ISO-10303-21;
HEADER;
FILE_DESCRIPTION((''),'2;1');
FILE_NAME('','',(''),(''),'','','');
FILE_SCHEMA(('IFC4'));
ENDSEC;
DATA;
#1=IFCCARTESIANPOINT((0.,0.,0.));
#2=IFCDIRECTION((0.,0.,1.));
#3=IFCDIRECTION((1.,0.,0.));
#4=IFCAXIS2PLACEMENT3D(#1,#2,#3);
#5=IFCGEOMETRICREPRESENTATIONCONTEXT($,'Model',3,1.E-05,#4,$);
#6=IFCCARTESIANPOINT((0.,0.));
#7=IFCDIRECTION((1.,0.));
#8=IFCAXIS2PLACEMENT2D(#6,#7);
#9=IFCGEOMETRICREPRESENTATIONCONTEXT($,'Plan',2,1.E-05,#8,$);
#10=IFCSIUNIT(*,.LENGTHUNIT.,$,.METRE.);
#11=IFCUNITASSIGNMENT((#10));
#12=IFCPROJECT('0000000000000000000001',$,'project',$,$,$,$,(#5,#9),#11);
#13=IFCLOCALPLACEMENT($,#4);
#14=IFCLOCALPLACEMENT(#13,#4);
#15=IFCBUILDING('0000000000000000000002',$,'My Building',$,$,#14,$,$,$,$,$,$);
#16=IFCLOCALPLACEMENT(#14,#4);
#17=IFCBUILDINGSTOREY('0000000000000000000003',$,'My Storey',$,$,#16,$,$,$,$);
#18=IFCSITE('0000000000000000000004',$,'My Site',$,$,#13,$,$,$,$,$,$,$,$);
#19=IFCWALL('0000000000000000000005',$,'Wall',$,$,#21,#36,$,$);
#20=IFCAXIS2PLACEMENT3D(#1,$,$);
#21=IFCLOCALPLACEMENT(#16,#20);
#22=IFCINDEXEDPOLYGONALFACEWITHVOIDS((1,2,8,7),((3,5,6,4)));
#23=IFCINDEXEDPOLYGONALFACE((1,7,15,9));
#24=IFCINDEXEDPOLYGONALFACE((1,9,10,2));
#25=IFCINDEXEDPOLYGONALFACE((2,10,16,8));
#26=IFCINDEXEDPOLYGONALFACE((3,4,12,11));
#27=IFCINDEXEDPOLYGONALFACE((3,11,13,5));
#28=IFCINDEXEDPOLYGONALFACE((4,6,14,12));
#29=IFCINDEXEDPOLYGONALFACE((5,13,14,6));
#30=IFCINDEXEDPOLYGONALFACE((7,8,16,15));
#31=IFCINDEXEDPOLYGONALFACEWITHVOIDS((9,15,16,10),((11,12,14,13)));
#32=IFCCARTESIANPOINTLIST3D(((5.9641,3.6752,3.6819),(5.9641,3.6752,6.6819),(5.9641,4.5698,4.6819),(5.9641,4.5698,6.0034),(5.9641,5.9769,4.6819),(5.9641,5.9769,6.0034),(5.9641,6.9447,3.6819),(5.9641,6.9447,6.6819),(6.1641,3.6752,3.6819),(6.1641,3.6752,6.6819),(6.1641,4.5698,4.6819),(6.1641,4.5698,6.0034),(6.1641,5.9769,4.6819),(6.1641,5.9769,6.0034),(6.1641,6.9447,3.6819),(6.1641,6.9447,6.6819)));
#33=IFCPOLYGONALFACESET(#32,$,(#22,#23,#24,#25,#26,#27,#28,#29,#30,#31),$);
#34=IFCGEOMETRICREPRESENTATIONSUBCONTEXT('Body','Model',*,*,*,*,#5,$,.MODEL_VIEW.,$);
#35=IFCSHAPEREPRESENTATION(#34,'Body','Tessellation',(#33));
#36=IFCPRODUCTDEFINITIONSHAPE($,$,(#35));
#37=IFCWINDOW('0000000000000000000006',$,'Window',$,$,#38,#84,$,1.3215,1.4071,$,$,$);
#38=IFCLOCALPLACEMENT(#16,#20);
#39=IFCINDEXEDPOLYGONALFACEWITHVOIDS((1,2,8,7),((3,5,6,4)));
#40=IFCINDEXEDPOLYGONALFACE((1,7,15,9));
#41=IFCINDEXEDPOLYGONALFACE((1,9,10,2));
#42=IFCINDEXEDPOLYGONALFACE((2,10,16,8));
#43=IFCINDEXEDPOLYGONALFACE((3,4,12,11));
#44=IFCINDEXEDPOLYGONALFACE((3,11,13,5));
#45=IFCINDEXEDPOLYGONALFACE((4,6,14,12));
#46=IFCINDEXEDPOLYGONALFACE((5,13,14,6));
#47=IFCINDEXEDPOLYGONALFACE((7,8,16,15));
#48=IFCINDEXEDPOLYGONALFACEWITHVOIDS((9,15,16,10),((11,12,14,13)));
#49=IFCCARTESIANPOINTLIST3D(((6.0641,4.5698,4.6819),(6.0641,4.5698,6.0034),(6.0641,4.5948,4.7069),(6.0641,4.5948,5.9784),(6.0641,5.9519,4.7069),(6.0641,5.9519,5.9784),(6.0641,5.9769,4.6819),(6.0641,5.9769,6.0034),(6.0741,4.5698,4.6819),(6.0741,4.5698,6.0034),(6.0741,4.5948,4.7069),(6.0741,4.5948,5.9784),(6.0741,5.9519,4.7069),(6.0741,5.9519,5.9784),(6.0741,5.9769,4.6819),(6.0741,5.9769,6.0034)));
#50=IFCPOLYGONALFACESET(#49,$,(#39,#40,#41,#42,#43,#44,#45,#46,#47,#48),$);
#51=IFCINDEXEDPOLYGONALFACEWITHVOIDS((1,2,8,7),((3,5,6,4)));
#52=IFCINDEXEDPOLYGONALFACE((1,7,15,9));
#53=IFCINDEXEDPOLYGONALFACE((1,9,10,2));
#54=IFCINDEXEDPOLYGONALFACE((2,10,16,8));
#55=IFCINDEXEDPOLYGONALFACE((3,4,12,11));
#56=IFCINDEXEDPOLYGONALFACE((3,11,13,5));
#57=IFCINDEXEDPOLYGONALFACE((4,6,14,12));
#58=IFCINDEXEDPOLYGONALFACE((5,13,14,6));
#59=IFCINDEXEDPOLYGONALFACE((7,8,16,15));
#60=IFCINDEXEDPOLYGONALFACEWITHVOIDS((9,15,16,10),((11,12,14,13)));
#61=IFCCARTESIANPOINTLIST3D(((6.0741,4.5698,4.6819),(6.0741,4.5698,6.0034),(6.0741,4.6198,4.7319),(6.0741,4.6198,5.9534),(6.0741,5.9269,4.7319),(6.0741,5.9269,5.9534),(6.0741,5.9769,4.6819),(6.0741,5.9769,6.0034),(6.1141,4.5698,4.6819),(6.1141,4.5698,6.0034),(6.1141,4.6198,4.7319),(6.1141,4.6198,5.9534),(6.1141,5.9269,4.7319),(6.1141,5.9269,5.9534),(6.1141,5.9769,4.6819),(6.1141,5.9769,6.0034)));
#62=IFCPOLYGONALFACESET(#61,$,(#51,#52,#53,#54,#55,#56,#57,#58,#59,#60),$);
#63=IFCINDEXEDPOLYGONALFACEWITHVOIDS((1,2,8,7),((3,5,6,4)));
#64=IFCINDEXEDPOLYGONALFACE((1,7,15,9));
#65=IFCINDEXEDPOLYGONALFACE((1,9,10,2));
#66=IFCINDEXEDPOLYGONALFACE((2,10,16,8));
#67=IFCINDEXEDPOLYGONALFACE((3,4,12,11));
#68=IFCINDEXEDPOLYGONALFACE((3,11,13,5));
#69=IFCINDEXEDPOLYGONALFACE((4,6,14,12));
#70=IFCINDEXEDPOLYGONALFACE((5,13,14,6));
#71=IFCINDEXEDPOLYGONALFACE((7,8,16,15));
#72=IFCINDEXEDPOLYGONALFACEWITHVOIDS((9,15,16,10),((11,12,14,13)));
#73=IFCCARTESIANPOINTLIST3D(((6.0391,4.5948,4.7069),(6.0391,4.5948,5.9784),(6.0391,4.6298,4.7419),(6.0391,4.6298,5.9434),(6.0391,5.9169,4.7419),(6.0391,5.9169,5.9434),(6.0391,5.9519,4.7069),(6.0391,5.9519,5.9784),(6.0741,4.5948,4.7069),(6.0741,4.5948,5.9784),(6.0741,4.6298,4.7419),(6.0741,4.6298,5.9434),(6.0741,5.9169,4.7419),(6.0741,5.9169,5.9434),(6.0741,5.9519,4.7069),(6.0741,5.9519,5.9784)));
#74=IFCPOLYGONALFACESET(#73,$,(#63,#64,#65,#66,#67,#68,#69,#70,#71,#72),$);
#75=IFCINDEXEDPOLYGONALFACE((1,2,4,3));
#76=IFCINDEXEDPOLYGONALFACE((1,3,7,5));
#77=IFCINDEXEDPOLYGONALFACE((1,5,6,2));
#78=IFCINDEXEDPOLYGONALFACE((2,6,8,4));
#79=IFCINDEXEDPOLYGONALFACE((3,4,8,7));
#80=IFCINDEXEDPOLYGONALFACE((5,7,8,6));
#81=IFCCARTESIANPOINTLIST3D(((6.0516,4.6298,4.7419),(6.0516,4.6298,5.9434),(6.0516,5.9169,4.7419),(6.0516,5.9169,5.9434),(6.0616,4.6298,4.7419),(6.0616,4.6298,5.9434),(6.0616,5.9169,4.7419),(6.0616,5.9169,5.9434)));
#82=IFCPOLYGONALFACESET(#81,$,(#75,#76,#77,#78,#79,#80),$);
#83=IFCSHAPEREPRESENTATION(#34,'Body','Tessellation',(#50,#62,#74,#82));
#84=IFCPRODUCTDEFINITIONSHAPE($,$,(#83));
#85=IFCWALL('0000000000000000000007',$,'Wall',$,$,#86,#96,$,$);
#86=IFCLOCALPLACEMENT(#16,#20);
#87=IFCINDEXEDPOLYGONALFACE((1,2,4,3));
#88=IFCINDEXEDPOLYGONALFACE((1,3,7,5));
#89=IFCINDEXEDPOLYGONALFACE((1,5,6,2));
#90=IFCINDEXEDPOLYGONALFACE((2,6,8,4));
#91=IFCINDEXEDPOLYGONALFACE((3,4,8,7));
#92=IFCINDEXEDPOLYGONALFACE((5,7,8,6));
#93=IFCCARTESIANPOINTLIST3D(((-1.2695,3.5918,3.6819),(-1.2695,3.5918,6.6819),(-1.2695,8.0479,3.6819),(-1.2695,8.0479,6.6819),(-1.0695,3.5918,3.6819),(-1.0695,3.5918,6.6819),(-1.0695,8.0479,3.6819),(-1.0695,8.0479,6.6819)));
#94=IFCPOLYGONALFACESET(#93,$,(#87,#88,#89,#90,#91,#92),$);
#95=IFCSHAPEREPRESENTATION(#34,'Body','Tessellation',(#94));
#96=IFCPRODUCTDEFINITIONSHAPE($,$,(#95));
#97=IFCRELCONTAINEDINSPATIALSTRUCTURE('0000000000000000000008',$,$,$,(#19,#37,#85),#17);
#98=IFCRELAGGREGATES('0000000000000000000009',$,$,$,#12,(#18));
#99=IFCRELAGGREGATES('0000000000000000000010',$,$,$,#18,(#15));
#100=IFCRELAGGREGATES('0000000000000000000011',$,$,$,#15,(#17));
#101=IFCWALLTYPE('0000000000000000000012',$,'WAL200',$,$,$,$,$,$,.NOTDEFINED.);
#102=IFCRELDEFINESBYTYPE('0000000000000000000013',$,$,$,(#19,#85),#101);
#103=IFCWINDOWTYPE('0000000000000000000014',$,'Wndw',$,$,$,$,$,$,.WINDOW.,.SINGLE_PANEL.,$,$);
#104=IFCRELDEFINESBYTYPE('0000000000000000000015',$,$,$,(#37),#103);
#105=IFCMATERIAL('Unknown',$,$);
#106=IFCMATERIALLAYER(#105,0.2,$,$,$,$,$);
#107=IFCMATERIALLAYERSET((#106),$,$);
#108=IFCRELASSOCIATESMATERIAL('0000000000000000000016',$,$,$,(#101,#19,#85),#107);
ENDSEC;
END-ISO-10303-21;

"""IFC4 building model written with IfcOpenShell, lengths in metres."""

from ifc_helpers import new_model, entity, si_unit, frame, origin_with_axes, origin_2d_with_axis, place, context, subcontext, project, spatial, line, indexed_curve, outline, extrude, shape, source, transform, mapped, material, layer, layer_set, layer_usage, type_object, type_shapes, element, fill, save


model = new_model("IFC4")

# Units and contexts
model_context = context("Model", 3, precision=1e-05, world=origin_with_axes())
plan_context = context("Plan", 2, precision=1e-05, world=origin_2d_with_axis())
body_context_1 = subcontext(model_context, "Body", "Model", "MODEL_VIEW")
body_context_2 = subcontext(plan_context, "Body", "Plan", "PLAN_VIEW")
ifc_project = project(units=[si_unit("LENGTHUNIT", "METRE")], contexts=[model_context, plan_context])

# Site, building, storey
site_placement = place(None, origin_with_axes())
site = spatial("IfcSite", under=ifc_project, at=site_placement, Name="My Site")
building_placement = place(site_placement, origin_with_axes())
building = spatial("IfcBuilding", under=site, at=building_placement, Name="My Building")
storey_placement = place(building_placement, origin_with_axes())
storey = spatial("IfcBuildingStorey", under=building, at=storey_placement, Name="My Storey")

# Shared definitions
ifc_material = material(Name="Unknown")

# Shared definitions
ifc_layer = layer(ifc_material, 0.2)
ifc_layer_set = layer_set([ifc_layer])
wall_type = type_object("IfcWallType", Name="WAL200", PredefinedType="NOTDEFINED", material=ifc_layer_set)
shared_shape_1 = source(origin_with_axes(), body_context_1, "Body", "SweptSolid", [
    extrude(outline(indexed_curve([(0.0, 0.0), (1.4071, 0.0), (1.4071, 1.3215), (0.0, 1.3215)], segments=[line(1, 2, 3, 4, 1)])), frame((0.0, -0.6, 0.0), z_axis=(0.0, -1.0, 0.0), x_axis=(1.0, 0.0, 0.0)), (0.0, 0.0, -1.0), 1.2),
])
window_type = type_object("IfcWindowType", Name="Wndw", PartitioningType="SINGLE_PANEL", PredefinedType="WINDOW")
shared_shape_2 = source(origin_with_axes(), body_context_1, "Body", "SweptSolid", [
    extrude(outline(indexed_curve([(0.0, 0.0), (1.4071, 0.0), (1.4071, 1.3215), (0.0, 1.3215)], segments=[line(1, 2, 3, 4, 1)]), holes=[indexed_curve([(0.025, 0.025), (1.3821, 0.025), (1.3821, 1.2965), (0.025, 1.2965)], segments=[line(1, 2, 3, 4, 1)])]), frame((0.0, 0.09, 0.0), z_axis=(0.0, -1.0, 0.0), x_axis=(1.0, 0.0, 0.0)), (0.0, 0.0, -1.0), 0.01),
    extrude(outline(indexed_curve([(0.0, 0.0), (1.4071, 0.0), (1.4071, 1.3215), (0.0, 1.3215)], segments=[line(1, 2, 3, 4, 1)]), holes=[indexed_curve([(0.05, 0.05), (1.3571, 0.05), (1.3571, 1.2715), (0.05, 1.2715)], segments=[line(1, 2, 3, 4, 1)])]), frame((0.0, 0.05, 0.0), z_axis=(0.0, -1.0, 0.0), x_axis=(1.0, 0.0, 0.0)), (0.0, 0.0, -1.0), 0.04),
    extrude(outline(indexed_curve([(0.0, 0.0), (1.3571, 0.0), (1.3571, 1.2715), (0.0, 1.2715)], segments=[line(1, 2, 3, 4, 1)]), holes=[indexed_curve([(0.035, 0.035), (1.3221, 0.035), (1.3221, 1.2365), (0.035, 1.2365)], segments=[line(1, 2, 3, 4, 1)])]), frame((0.025, 0.09, 0.025), z_axis=(0.0, -1.0, 0.0), x_axis=(1.0, 0.0, 0.0)), (0.0, 0.0, -1.0), 0.035),
    extrude(outline(indexed_curve([(0.035, 0.035), (1.3221, 0.035), (1.3221, 1.2365), (0.035, 1.2365)], segments=[line(1, 2, 3, 4, 1)])), frame((0.025, 0.1025, 0.025), z_axis=(0.0, -1.0, 0.0), x_axis=(1.0, 0.0, 0.0)), (0.0, 0.0, -1.0), 0.01),
])
shared_shape_3 = source(origin_with_axes(), body_context_2, "Body", "Curve2D", [
    entity("IfcIndexedPolyCurve", entity("IfcCartesianPointList2D", [[0.05, 0.05], [1.3571, 0.05]])),
    entity("IfcIndexedPolyCurve", entity("IfcCartesianPointList2D", [[0.0, 0.1], [0.025, 0.1], [0.025, 0.09], [0.05, 0.09], [0.05, 0.05], [0.0, 0.05]]), [entity("IfcLineIndex", [1, 2, 3, 4, 5, 6, 1])]),
    entity("IfcIndexedPolyCurve", entity("IfcCartesianPointList2D", [[1.4071, 0.1], [1.3821, 0.1], [1.3821, 0.09], [1.3571, 0.09], [1.3571, 0.05], [1.4071, 0.05]]), [entity("IfcLineIndex", [1, 2, 3, 4, 5, 6, 1])]),
    entity("IfcIndexedPolyCurve", entity("IfcCartesianPointList2D", [[0.025, 0.09], [0.06, 0.09], [0.06, 0.125], [0.025, 0.125]]), [entity("IfcLineIndex", [1, 2, 3, 4, 1])]),
    entity("IfcIndexedPolyCurve", entity("IfcCartesianPointList2D", [[1.3821, 0.09], [1.3471, 0.09], [1.3471, 0.125], [1.3821, 0.125]]), [entity("IfcLineIndex", [1, 2, 3, 4, 1])]),
    entity("IfcIndexedPolyCurve", entity("IfcCartesianPointList2D", [[0.06, 0.09], [1.3471, 0.09]])),
    entity("IfcIndexedPolyCurve", entity("IfcCartesianPointList2D", [[0.06, 0.125], [1.3471, 0.125]])),
    entity("IfcIndexedPolyCurve", entity("IfcCartesianPointList2D", [[0.06, 0.1075], [1.3471, 0.1075]])),
])
type_shapes(window_type, [shared_shape_2, shared_shape_3])

# Wall, opening, window
ifc_layer_usage_1 = layer_usage(ifc_layer_set, "AXIS2", "POSITIVE", 0.0)
wall_1_placement = place(storey_placement, frame((5.9641, 6.9447, 3.6819), z_axis=(0.0, 0.0, 1.0), x_axis=(0.0, -1.0, 0.0)))
wall_1 = element("IfcWall", 1, at=wall_1_placement, inside=storey, type_object=wall_type, material=ifc_layer_usage_1, Name="Wall", context=body_context_1, shape_type="SweptSolid", body=[
    extrude(outline(indexed_curve([(0.0, 0.0), (0.0, 0.2), (3.2695, 0.2), (3.2695, 0.0)], segments=[line(1, 2, 3, 4, 1)])), origin_with_axes(), (0.0, 0.0, 1.0), 3.0),
])
opening_1_placement = place(wall_1_placement, frame((2.3749, 0.2, 1.0), z_axis=(0.0, 0.0, 1.0), x_axis=(-1.0, 0.0, 0.0)))
opening_1 = element("IfcOpeningElement", 2, at=opening_1_placement, cuts=wall_1, PredefinedType="OPENING", context=body_context_1, shape_type="MappedRepresentation", body=[
    mapped(shared_shape_1, transform((0.0, 0.0, 0.0), x_axis=(1.0, 0.0, 0.0), y_axis=(0.0, 1.0, 0.0), z_axis=(0.0, 0.0, 1.0), scale=1.0)),
])
window_1_placement = place(opening_1_placement, frame((0.0, 0.0, 0.0), z_axis=(0.0, 0.0, 1.0), x_axis=(1.0, 0.0, 0.0)))
window_1 = element("IfcWindow", 3, at=window_1_placement, inside=storey, type_object=window_type, Name="Window", OverallHeight=1.3215, OverallWidth=1.4071, shapes=[
    shape(body_context_1, "Body", "MappedRepresentation", [mapped(shared_shape_2, transform((0.0, 0.0, 0.0), x_axis=(1.0, 0.0, 0.0), y_axis=(0.0, 1.0, 0.0), z_axis=(0.0, 0.0, 1.0), scale=1.0))]),
    shape(body_context_2, "Body", "MappedRepresentation", [mapped(shared_shape_3, transform((0.0, 0.0, 0.0), x_axis=(1.0, 0.0, 0.0), y_axis=(0.0, 1.0, 0.0), z_axis=(0.0, 0.0, 1.0), scale=1.0))]),
])
fill(opening_1, window_1)

# Wall
ifc_layer_usage_2 = layer_usage(ifc_layer_set, "AXIS2", "POSITIVE", 0.0)
wall_2_placement = place(storey_placement, frame((-1.0695, 3.5918, 3.6819), z_axis=(0.0, 0.0, 1.0), x_axis=(0.0, 1.0, 0.0)))
element("IfcWall", 4, at=wall_2_placement, inside=storey, type_object=wall_type, material=ifc_layer_usage_2, Name="Wall", context=body_context_1, shape_type="SweptSolid", body=[
    extrude(outline(indexed_curve([(0.0, 0.0), (0.0, 0.2), (4.4561, 0.2), (4.4561, 0.0)], segments=[line(1, 2, 3, 4, 1)])), origin_with_axes(), (0.0, 0.0, 1.0), 3.0),
])

save(model, "model.ifc")
